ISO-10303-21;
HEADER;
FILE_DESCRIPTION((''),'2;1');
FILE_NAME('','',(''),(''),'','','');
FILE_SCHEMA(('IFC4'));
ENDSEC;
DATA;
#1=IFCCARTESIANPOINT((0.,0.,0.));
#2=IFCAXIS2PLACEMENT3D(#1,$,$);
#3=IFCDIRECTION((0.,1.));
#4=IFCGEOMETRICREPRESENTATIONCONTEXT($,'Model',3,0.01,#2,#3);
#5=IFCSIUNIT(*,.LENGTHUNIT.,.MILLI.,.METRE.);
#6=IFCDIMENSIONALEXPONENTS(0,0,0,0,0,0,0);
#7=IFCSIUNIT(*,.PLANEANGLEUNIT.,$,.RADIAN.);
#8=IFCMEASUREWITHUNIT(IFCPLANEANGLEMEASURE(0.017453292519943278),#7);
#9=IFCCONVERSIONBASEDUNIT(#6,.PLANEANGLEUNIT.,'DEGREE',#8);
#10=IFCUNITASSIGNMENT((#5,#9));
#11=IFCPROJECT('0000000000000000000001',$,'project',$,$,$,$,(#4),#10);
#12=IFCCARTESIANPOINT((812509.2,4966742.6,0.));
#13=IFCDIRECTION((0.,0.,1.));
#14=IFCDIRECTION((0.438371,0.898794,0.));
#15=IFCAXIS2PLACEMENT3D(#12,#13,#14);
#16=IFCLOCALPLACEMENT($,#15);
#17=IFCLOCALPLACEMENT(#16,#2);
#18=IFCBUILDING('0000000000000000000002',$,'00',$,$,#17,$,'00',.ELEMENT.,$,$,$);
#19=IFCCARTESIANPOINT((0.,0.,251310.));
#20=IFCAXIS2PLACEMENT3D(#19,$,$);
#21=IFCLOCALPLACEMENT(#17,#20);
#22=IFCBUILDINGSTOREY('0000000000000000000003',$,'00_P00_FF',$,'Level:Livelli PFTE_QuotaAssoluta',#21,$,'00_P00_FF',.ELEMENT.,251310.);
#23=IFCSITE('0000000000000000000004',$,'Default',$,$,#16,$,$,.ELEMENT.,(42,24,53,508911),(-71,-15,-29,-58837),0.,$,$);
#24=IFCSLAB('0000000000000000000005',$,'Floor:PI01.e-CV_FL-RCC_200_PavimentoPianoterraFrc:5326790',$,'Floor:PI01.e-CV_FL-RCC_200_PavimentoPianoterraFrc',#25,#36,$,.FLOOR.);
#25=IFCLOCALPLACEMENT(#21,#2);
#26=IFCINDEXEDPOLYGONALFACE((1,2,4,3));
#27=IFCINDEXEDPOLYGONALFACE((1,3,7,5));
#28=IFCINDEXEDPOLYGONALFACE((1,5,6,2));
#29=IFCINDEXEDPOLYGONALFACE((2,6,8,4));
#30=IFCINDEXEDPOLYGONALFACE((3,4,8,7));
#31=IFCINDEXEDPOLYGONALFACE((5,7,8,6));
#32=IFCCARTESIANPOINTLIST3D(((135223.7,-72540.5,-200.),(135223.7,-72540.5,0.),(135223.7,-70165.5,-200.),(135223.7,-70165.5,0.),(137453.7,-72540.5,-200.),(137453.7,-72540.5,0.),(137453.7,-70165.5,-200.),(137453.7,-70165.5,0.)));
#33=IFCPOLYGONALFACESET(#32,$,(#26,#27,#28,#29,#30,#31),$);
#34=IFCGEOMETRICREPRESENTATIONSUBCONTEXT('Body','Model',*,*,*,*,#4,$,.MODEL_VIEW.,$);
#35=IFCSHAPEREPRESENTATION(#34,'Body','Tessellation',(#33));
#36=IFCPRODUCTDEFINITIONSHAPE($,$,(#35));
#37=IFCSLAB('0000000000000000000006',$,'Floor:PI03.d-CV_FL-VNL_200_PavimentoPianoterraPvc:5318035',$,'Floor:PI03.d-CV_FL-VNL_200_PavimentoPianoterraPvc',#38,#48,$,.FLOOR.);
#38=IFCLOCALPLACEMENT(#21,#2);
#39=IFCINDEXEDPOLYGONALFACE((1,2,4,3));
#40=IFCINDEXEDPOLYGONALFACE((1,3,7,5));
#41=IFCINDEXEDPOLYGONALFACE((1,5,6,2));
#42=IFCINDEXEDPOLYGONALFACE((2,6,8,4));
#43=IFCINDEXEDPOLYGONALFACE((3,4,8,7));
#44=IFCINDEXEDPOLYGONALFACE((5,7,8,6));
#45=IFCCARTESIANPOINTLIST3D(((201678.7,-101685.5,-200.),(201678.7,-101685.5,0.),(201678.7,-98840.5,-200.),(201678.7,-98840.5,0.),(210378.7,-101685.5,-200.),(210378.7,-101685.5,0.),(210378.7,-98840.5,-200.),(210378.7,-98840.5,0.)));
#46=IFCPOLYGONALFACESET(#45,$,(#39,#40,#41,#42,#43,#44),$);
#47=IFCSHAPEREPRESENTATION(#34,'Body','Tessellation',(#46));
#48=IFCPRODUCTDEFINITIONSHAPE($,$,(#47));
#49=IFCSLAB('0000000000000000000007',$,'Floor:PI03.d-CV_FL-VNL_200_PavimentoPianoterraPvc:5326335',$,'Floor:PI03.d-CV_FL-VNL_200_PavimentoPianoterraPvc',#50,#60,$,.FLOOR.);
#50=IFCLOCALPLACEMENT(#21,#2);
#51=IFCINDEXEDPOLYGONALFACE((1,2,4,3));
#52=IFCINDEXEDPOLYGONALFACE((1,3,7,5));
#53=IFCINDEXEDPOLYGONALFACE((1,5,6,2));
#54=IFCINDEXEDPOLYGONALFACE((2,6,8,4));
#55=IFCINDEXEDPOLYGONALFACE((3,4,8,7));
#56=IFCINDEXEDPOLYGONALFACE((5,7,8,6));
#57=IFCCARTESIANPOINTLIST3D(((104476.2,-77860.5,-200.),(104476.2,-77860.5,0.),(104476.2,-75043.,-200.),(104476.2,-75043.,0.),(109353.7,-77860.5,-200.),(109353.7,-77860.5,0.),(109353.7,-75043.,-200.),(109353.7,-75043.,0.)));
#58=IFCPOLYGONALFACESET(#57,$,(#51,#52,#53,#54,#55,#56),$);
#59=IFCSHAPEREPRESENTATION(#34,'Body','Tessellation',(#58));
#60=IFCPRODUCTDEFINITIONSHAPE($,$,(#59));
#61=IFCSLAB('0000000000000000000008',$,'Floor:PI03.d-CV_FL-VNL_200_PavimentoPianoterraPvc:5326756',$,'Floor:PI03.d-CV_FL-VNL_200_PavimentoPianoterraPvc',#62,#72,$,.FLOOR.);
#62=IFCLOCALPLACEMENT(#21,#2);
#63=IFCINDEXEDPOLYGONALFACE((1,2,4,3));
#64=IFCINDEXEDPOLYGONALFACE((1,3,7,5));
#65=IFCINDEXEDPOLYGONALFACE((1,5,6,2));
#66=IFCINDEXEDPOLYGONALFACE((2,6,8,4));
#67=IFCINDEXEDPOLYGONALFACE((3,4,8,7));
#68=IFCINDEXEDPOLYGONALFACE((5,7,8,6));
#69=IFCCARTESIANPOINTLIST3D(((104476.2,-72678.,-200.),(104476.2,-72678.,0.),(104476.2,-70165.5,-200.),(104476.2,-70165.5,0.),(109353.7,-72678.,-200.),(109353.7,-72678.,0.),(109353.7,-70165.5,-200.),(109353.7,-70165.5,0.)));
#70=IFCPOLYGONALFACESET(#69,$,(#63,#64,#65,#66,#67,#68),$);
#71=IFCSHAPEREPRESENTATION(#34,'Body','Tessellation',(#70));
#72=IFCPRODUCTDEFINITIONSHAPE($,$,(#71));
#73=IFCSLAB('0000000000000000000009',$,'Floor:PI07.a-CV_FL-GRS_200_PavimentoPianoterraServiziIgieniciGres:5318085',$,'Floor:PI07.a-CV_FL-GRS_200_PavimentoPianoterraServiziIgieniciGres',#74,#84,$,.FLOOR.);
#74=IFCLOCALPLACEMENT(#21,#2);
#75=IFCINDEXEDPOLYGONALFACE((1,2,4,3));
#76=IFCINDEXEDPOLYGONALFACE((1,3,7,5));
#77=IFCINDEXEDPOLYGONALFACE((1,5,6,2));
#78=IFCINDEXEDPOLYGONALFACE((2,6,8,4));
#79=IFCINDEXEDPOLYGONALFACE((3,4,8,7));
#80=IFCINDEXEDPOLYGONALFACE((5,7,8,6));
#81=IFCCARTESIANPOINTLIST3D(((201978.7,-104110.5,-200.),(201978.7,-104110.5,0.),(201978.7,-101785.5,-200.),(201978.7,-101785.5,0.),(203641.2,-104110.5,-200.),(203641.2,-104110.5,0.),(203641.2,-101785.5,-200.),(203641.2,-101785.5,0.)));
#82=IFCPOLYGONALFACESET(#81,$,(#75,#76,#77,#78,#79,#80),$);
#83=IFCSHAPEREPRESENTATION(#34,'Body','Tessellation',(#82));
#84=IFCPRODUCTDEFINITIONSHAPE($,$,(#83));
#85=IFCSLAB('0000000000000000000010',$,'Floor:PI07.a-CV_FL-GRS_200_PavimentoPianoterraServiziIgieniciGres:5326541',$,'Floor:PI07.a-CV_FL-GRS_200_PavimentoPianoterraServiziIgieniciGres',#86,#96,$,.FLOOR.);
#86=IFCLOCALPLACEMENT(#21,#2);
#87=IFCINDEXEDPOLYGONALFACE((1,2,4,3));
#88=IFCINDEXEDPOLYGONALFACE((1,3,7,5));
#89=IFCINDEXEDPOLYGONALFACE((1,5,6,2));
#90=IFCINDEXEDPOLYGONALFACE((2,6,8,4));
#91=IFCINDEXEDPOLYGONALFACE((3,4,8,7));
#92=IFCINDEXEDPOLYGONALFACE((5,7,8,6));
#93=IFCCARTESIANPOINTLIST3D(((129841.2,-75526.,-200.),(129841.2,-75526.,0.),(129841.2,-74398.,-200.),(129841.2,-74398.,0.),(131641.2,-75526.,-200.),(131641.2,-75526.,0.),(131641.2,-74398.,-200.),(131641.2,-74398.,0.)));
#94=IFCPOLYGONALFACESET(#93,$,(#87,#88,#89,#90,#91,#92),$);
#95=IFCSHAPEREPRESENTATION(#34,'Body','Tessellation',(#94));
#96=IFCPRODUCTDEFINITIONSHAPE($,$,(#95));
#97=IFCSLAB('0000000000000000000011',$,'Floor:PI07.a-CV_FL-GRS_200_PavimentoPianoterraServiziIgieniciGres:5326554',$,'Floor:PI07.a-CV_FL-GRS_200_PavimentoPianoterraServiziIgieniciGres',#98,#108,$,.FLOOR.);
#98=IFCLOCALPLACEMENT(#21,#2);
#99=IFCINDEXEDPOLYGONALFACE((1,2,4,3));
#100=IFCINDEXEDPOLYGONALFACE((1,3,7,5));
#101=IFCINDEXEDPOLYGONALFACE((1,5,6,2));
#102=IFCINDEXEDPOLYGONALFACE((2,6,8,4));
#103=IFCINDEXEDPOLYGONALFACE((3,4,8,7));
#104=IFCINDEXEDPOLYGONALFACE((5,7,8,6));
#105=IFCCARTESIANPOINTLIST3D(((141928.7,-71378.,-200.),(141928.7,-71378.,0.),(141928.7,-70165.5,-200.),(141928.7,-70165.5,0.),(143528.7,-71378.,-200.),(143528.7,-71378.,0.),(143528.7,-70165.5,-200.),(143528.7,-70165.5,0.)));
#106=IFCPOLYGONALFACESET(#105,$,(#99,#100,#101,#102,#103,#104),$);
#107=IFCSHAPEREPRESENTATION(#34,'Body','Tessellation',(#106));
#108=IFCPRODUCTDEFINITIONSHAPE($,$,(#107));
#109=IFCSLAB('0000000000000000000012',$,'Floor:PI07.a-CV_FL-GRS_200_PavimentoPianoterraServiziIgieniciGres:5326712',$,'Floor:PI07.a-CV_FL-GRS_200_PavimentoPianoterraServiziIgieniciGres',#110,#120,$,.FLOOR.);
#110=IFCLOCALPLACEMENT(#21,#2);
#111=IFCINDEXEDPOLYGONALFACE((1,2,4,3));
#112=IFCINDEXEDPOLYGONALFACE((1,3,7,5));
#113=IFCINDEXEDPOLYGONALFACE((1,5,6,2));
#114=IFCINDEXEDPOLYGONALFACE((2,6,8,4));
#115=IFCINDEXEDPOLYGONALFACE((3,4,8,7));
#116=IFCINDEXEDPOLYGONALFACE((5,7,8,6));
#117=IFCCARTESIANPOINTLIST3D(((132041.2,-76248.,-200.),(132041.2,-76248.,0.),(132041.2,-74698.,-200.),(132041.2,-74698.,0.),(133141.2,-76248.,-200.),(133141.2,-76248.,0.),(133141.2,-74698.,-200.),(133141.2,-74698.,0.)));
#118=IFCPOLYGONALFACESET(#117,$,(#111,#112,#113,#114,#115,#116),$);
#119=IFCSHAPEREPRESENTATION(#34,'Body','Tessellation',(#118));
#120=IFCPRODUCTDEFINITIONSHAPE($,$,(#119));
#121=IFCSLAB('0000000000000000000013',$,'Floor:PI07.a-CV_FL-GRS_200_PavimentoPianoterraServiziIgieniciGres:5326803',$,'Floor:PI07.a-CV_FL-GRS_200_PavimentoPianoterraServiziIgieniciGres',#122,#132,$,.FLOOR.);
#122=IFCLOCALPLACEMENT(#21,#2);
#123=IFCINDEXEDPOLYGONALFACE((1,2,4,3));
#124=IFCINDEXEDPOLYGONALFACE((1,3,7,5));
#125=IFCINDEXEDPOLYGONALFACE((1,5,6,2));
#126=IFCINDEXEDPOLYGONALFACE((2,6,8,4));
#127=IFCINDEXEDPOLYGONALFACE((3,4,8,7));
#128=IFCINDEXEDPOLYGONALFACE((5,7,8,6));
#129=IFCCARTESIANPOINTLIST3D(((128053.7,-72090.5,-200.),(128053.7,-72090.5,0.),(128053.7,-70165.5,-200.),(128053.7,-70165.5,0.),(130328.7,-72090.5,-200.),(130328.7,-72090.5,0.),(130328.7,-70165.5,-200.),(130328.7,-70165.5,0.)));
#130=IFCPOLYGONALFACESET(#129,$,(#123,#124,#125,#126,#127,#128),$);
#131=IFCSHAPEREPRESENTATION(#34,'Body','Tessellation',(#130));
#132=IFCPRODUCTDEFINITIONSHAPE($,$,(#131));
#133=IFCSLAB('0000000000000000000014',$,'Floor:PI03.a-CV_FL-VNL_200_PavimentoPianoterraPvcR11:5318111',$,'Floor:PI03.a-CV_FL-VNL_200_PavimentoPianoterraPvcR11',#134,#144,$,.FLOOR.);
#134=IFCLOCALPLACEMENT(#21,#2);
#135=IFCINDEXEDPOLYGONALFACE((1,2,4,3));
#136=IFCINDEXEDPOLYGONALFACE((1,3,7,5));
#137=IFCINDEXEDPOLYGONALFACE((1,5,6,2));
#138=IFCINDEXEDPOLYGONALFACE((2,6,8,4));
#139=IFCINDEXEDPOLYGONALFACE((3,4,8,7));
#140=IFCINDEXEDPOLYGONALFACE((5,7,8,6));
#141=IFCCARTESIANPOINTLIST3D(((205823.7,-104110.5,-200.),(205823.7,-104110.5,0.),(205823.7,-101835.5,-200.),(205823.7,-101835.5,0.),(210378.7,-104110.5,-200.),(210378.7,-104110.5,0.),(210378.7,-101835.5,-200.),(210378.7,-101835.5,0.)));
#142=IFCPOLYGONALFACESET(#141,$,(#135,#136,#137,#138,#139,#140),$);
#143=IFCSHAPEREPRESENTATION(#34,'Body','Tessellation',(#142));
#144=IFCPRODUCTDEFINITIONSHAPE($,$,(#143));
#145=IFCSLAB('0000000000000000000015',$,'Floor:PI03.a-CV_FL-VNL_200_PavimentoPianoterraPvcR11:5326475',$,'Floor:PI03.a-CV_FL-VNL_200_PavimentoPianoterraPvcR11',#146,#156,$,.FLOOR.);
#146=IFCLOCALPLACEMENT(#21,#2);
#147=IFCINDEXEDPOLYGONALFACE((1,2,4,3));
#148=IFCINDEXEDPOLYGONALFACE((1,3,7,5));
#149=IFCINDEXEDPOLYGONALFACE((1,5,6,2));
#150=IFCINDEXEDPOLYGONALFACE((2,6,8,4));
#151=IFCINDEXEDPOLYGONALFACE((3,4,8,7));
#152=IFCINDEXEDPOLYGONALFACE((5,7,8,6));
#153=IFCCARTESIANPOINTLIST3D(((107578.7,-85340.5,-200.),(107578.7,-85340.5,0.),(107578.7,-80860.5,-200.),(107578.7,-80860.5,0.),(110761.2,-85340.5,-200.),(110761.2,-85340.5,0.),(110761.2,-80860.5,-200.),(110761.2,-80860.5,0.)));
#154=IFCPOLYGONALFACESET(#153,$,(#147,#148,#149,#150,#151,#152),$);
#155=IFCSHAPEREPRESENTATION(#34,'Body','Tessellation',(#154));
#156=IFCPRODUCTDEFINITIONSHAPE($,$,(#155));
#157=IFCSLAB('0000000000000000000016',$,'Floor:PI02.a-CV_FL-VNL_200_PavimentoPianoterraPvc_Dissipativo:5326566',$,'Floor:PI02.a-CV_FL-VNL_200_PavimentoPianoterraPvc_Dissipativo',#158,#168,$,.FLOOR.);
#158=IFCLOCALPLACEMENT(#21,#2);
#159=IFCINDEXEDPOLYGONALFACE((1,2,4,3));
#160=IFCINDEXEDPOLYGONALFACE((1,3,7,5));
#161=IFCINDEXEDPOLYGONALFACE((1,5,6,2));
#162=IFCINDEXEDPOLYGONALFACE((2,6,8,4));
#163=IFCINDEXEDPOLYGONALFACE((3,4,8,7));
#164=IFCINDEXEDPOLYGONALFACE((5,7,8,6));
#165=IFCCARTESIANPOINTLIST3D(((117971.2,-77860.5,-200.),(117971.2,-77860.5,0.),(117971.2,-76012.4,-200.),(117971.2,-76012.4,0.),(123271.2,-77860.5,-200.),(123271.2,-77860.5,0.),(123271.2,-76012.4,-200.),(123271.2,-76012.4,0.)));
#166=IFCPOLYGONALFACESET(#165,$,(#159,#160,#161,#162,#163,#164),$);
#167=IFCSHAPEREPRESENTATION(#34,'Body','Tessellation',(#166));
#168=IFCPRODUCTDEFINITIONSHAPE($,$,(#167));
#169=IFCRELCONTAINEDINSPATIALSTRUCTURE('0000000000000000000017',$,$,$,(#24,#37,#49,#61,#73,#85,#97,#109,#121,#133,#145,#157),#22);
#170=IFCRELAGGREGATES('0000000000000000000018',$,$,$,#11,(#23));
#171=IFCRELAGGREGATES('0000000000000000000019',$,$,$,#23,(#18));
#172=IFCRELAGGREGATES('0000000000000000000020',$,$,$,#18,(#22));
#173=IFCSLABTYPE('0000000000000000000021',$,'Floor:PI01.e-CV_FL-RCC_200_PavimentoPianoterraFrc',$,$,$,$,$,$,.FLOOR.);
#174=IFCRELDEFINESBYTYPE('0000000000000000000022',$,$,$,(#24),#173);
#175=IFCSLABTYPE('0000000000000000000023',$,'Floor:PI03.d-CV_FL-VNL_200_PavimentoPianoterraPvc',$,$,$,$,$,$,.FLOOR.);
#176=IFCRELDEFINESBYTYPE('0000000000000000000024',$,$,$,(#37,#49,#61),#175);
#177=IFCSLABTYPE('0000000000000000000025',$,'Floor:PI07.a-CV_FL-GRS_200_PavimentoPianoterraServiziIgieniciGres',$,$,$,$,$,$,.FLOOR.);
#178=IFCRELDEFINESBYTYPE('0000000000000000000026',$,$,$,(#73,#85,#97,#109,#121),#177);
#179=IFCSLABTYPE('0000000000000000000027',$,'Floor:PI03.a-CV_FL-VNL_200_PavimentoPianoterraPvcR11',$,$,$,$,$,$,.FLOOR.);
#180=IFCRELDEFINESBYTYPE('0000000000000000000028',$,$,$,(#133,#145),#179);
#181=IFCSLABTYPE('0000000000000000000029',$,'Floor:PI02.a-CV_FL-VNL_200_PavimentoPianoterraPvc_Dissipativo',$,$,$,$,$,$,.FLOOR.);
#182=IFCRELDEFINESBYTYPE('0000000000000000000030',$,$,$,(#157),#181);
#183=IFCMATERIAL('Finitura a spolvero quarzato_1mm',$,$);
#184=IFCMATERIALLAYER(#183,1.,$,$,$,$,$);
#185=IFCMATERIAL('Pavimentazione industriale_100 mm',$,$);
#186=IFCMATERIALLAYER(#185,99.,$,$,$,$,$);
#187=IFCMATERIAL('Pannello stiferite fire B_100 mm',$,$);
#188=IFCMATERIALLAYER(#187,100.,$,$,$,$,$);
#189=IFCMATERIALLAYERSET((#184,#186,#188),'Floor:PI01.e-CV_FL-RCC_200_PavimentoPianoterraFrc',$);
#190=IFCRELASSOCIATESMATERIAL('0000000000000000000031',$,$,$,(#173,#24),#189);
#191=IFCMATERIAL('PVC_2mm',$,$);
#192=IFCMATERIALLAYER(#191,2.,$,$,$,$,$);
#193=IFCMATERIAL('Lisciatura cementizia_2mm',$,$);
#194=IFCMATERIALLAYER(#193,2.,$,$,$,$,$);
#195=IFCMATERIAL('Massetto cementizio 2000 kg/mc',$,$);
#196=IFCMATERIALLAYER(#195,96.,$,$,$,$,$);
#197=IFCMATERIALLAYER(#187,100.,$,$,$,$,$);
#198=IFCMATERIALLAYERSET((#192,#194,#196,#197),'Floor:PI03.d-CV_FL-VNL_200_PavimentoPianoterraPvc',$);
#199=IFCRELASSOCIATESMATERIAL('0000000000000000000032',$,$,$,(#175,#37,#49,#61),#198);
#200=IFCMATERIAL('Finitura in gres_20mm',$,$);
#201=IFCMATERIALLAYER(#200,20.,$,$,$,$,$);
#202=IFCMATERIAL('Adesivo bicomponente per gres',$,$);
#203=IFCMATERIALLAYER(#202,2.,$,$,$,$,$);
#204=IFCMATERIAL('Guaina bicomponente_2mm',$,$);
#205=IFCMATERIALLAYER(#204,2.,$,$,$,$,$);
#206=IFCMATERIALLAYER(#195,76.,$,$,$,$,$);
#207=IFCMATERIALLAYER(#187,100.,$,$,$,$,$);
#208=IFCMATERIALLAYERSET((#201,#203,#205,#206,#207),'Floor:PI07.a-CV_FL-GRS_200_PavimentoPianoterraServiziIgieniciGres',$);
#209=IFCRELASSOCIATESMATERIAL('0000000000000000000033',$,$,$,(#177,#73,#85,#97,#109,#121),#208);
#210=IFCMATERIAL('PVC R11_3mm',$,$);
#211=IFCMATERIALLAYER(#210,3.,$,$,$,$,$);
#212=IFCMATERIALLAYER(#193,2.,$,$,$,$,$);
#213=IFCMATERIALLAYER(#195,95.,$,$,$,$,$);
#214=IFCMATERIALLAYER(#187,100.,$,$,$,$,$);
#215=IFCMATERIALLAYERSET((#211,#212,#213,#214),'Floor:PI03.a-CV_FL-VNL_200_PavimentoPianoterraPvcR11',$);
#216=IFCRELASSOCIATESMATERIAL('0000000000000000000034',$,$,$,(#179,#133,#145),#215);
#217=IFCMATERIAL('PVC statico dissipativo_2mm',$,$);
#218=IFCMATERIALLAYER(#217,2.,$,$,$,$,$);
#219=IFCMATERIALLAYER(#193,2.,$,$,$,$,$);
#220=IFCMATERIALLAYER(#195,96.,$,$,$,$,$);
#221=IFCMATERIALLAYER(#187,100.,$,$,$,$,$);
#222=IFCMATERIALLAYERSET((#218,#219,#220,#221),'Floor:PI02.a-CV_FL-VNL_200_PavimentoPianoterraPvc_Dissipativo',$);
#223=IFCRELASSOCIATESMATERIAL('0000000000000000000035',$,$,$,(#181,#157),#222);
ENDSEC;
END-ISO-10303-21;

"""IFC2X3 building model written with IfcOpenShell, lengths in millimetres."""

from ifc_helpers import new_model, entity, si_unit, converted_unit, direction, frame, frame_2d, origin, origin_2d_with_axis, place, context, subcontext, project, spatial, rectangle, extrude, material, layer, layer_set, layer_usage, type_object, element, save


model = new_model("IFC2X3")

# Units and contexts
model_context = context("Model", 3, precision=0.01, world=origin(), true_north=direction((0.0, 1.0)))
body_context = subcontext(model_context, "Body", "Model", "MODEL_VIEW")
ifc_project = project(units=[si_unit("LENGTHUNIT", "METRE", prefix="MILLI"), converted_unit("PLANEANGLEUNIT", "DEGREE", entity("IfcPlaneAngleMeasure", 0.017453292519943278), si_unit("PLANEANGLEUNIT", "RADIAN"), dimensions=[0, 0, 0, 0, 0, 0, 0])], contexts=[model_context])

# Site, building, storey
site_placement = place(None, frame((812509.2, 4966742.6, 0.0), z_axis=(0.0, 0.0, 1.0), x_axis=(0.438371, 0.898794, 0.0)))
site = spatial("IfcSite", under=ifc_project, at=site_placement, Name="Default", CompositionType="ELEMENT", RefLatitude=(42, 24, 53, 508911), RefLongitude=(-71, -15, -29, -58837), RefElevation=0.0)
building_placement = place(site_placement, origin())
building = spatial("IfcBuilding", under=site, at=building_placement, Name="00", LongName="00", CompositionType="ELEMENT")
storey_placement = place(building_placement, frame((0.0, 0.0, 251310.0)))
storey = spatial("IfcBuildingStorey", under=building, at=storey_placement, Name="00_P00_FF", ObjectType="Level:Livelli PFTE_QuotaAssoluta", LongName="00_P00_FF", CompositionType="ELEMENT", Elevation=251310.0)

# Slabs
ifc_material_1 = material(Name="Finitura a spolvero quarzato_1mm")
ifc_layer_1 = layer(ifc_material_1, 1.0)
ifc_material_2 = material(Name="Pavimentazione industriale_100 mm")
ifc_layer_2 = layer(ifc_material_2, 99.0)
ifc_material_3 = material(Name="Pannello stiferite fire B_100 mm")
ifc_layer_3 = layer(ifc_material_3, 100.0)
ifc_layer_set_1 = layer_set([ifc_layer_1, ifc_layer_2, ifc_layer_3], Name="Floor:PI01.e-CV_FL-RCC_200_PavimentoPianoterraFrc")
slab_type_1 = type_object("IfcSlabType", Name="Floor:PI01.e-CV_FL-RCC_200_PavimentoPianoterraFrc", PredefinedType="FLOOR", material=ifc_layer_set_1)
ifc_layer_usage_1 = layer_usage(ifc_layer_set_1, "AXIS3", "POSITIVE", 0.0)
slab_1_placement = place(storey_placement, origin())
element("IfcSlab", 1, at=slab_1_placement, inside=storey, type_object=slab_type_1, material=ifc_layer_usage_1, Name="Floor:PI01.e-CV_FL-RCC_200_PavimentoPianoterraFrc:5326790", ObjectType="Floor:PI01.e-CV_FL-RCC_200_PavimentoPianoterraFrc", PredefinedType="FLOOR", context=body_context, shape_type="SweptSolid", body=[
    extrude(rectangle(XDim=2375.0, YDim=2230.0, at=frame_2d((0.0, 0.0), x_axis=(1.0, 0.0))), frame((136338.7, -71353.0, 0.0), z_axis=(0.0, 0.0, -1.0), x_axis=(0.0, 1.0, 0.0)), (0.0, 0.0, 1.0), 200.0),
])
ifc_material_4 = material(Name="PVC_2mm")
ifc_layer_4 = layer(ifc_material_4, 2.0)
ifc_material_5 = material(Name="Lisciatura cementizia_2mm")
ifc_layer_5 = layer(ifc_material_5, 2.0)
ifc_material_6 = material(Name="Massetto cementizio 2000 kg/mc")
ifc_layer_6 = layer(ifc_material_6, 96.0)
ifc_layer_7 = layer(ifc_material_3, 100.0)
ifc_layer_set_2 = layer_set([ifc_layer_4, ifc_layer_5, ifc_layer_6, ifc_layer_7], Name="Floor:PI03.d-CV_FL-VNL_200_PavimentoPianoterraPvc")
ifc_layer_usage_2 = layer_usage(ifc_layer_set_2, "AXIS3", "POSITIVE", 0.0)
slab_type_2 = type_object("IfcSlabType", Name="Floor:PI03.d-CV_FL-VNL_200_PavimentoPianoterraPvc", PredefinedType="FLOOR", material=ifc_layer_set_2)
slab_2_placement = place(storey_placement, origin())
element("IfcSlab", 2, at=slab_2_placement, inside=storey, type_object=slab_type_2, material=ifc_layer_usage_2, Name="Floor:PI03.d-CV_FL-VNL_200_PavimentoPianoterraPvc:5318035", ObjectType="Floor:PI03.d-CV_FL-VNL_200_PavimentoPianoterraPvc", PredefinedType="FLOOR", context=body_context, shape_type="SweptSolid", body=[
    extrude(rectangle(XDim=2845.0, YDim=8700.0, at=frame_2d((0.0, 0.0), x_axis=(1.0, 0.0))), frame((206028.7, -100263.0, 0.0), z_axis=(0.0, 0.0, -1.0), x_axis=(0.0, 1.0, 0.0)), (0.0, 0.0, 1.0), 200.0),
])
ifc_layer_usage_3 = layer_usage(ifc_layer_set_2, "AXIS3", "POSITIVE", 0.0)
slab_3_placement = place(storey_placement, origin())
element("IfcSlab", 3, at=slab_3_placement, inside=storey, type_object=slab_type_2, material=ifc_layer_usage_3, Name="Floor:PI03.d-CV_FL-VNL_200_PavimentoPianoterraPvc:5326335", ObjectType="Floor:PI03.d-CV_FL-VNL_200_PavimentoPianoterraPvc", PredefinedType="FLOOR", context=body_context, shape_type="SweptSolid", body=[
    extrude(rectangle(XDim=4877.5, YDim=2817.5, at=frame_2d((0.0, 0.0), x_axis=(1.0, 0.0))), frame((106914.9, -76451.7, 0.0), z_axis=(0.0, 0.0, -1.0), x_axis=(1.0, 0.0, 0.0)), (0.0, 0.0, 1.0), 200.0),
])
ifc_layer_usage_4 = layer_usage(ifc_layer_set_2, "AXIS3", "POSITIVE", 0.0)
slab_4_placement = place(storey_placement, origin())
element("IfcSlab", 4, at=slab_4_placement, inside=storey, type_object=slab_type_2, material=ifc_layer_usage_4, Name="Floor:PI03.d-CV_FL-VNL_200_PavimentoPianoterraPvc:5326756", ObjectType="Floor:PI03.d-CV_FL-VNL_200_PavimentoPianoterraPvc", PredefinedType="FLOOR", context=body_context, shape_type="SweptSolid", body=[
    extrude(rectangle(XDim=2512.5, YDim=4877.5, at=frame_2d((0.0, 0.0), x_axis=(1.0, 0.0))), frame((106914.9, -71421.7, 0.0), z_axis=(0.0, 0.0, -1.0), x_axis=(0.0, -1.0, 0.0)), (0.0, 0.0, 1.0), 200.0),
])
ifc_material_7 = material(Name="Finitura in gres_20mm")
ifc_layer_8 = layer(ifc_material_7, 20.0)
ifc_material_8 = material(Name="Adesivo bicomponente per gres")
ifc_layer_9 = layer(ifc_material_8, 2.0)
ifc_material_9 = material(Name="Guaina bicomponente_2mm")
ifc_layer_10 = layer(ifc_material_9, 2.0)
ifc_layer_11 = layer(ifc_material_6, 76.0)
ifc_layer_12 = layer(ifc_material_3, 100.0)
ifc_layer_set_3 = layer_set([ifc_layer_8, ifc_layer_9, ifc_layer_10, ifc_layer_11, ifc_layer_12], Name="Floor:PI07.a-CV_FL-GRS_200_PavimentoPianoterraServiziIgieniciGres")
ifc_layer_usage_5 = layer_usage(ifc_layer_set_3, "AXIS3", "POSITIVE", 0.0)
slab_type_3 = type_object("IfcSlabType", Name="Floor:PI07.a-CV_FL-GRS_200_PavimentoPianoterraServiziIgieniciGres", PredefinedType="FLOOR", material=ifc_layer_set_3)
slab_5_placement = place(storey_placement, origin())
element("IfcSlab", 5, at=slab_5_placement, inside=storey, type_object=slab_type_3, material=ifc_layer_usage_5, Name="Floor:PI07.a-CV_FL-GRS_200_PavimentoPianoterraServiziIgieniciGres:5318085", ObjectType="Floor:PI07.a-CV_FL-GRS_200_PavimentoPianoterraServiziIgieniciGres", PredefinedType="FLOOR", context=body_context, shape_type="SweptSolid", body=[
    extrude(rectangle(XDim=2325.0, YDim=1662.5, at=frame_2d((0.0, 0.0), x_axis=(1.0, 0.0))), frame((202809.9, -102948.0, 0.0), z_axis=(0.0, 0.0, -1.0), x_axis=(0.0, 1.0, 0.0)), (0.0, 0.0, 1.0), 200.0),
])
ifc_layer_usage_6 = layer_usage(ifc_layer_set_3, "AXIS3", "POSITIVE", 0.0)
slab_6_placement = place(storey_placement, origin())
element("IfcSlab", 6, at=slab_6_placement, inside=storey, type_object=slab_type_3, material=ifc_layer_usage_6, Name="Floor:PI07.a-CV_FL-GRS_200_PavimentoPianoterraServiziIgieniciGres:5326541", ObjectType="Floor:PI07.a-CV_FL-GRS_200_PavimentoPianoterraServiziIgieniciGres", PredefinedType="FLOOR", context=body_context, shape_type="SweptSolid", body=[
    extrude(rectangle(XDim=1128.0, YDim=1800.0, at=frame_2d((0.0, 0.0), x_axis=(1.0, 0.0))), frame((130741.2, -74962.0, 0.0), z_axis=(0.0, 0.0, -1.0), x_axis=(0.0, 1.0, 0.0)), (0.0, 0.0, 1.0), 200.0),
])
ifc_layer_usage_7 = layer_usage(ifc_layer_set_3, "AXIS3", "POSITIVE", 0.0)
slab_7_placement = place(storey_placement, origin())
element("IfcSlab", 7, at=slab_7_placement, inside=storey, type_object=slab_type_3, material=ifc_layer_usage_7, Name="Floor:PI07.a-CV_FL-GRS_200_PavimentoPianoterraServiziIgieniciGres:5326554", ObjectType="Floor:PI07.a-CV_FL-GRS_200_PavimentoPianoterraServiziIgieniciGres", PredefinedType="FLOOR", context=body_context, shape_type="SweptSolid", body=[
    extrude(rectangle(XDim=1212.5, YDim=1600.0, at=frame_2d((0.0, 0.0), x_axis=(1.0, 0.0))), frame((142728.7, -70771.7, 0.0), z_axis=(0.0, 0.0, -1.0), x_axis=(0.0, 1.0, 0.0)), (0.0, 0.0, 1.0), 200.0),
])
ifc_layer_usage_8 = layer_usage(ifc_layer_set_3, "AXIS3", "POSITIVE", 0.0)
slab_8_placement = place(storey_placement, origin())
element("IfcSlab", 8, at=slab_8_placement, inside=storey, type_object=slab_type_3, material=ifc_layer_usage_8, Name="Floor:PI07.a-CV_FL-GRS_200_PavimentoPianoterraServiziIgieniciGres:5326712", ObjectType="Floor:PI07.a-CV_FL-GRS_200_PavimentoPianoterraServiziIgieniciGres", PredefinedType="FLOOR", context=body_context, shape_type="SweptSolid", body=[
    extrude(rectangle(XDim=1550.0, YDim=1100.0, at=frame_2d((0.0, 0.0), x_axis=(1.0, 0.0))), frame((132591.2, -75473.0, 0.0), z_axis=(0.0, 0.0, -1.0), x_axis=(0.0, 1.0, 0.0)), (0.0, 0.0, 1.0), 200.0),
])
ifc_layer_usage_9 = layer_usage(ifc_layer_set_3, "AXIS3", "POSITIVE", 0.0)
slab_9_placement = place(storey_placement, origin())
element("IfcSlab", 9, at=slab_9_placement, inside=storey, type_object=slab_type_3, material=ifc_layer_usage_9, Name="Floor:PI07.a-CV_FL-GRS_200_PavimentoPianoterraServiziIgieniciGres:5326803", ObjectType="Floor:PI07.a-CV_FL-GRS_200_PavimentoPianoterraServiziIgieniciGres", PredefinedType="FLOOR", context=body_context, shape_type="SweptSolid", body=[
    extrude(rectangle(XDim=1925.0, YDim=2275.0, at=frame_2d((0.0, 0.0), x_axis=(1.0, 0.0))), frame((129191.2, -71128.0, 0.0), z_axis=(0.0, 0.0, -1.0), x_axis=(0.0, 1.0, 0.0)), (0.0, 0.0, 1.0), 200.0),
])
ifc_material_10 = material(Name="PVC R11_3mm")
ifc_layer_13 = layer(ifc_material_10, 3.0)
ifc_layer_14 = layer(ifc_material_5, 2.0)
ifc_layer_15 = layer(ifc_material_6, 95.0)
ifc_layer_16 = layer(ifc_material_3, 100.0)
ifc_layer_set_4 = layer_set([ifc_layer_13, ifc_layer_14, ifc_layer_15, ifc_layer_16], Name="Floor:PI03.a-CV_FL-VNL_200_PavimentoPianoterraPvcR11")
ifc_layer_usage_10 = layer_usage(ifc_layer_set_4, "AXIS3", "POSITIVE", 0.0)
slab_type_4 = type_object("IfcSlabType", Name="Floor:PI03.a-CV_FL-VNL_200_PavimentoPianoterraPvcR11", PredefinedType="FLOOR", material=ifc_layer_set_4)
slab_10_placement = place(storey_placement, origin())
element("IfcSlab", 10, at=slab_10_placement, inside=storey, type_object=slab_type_4, material=ifc_layer_usage_10, Name="Floor:PI03.a-CV_FL-VNL_200_PavimentoPianoterraPvcR11:5318111", ObjectType="Floor:PI03.a-CV_FL-VNL_200_PavimentoPianoterraPvcR11", PredefinedType="FLOOR", context=body_context, shape_type="SweptSolid", body=[
    extrude(rectangle(XDim=2275.0, YDim=4555.0, at=origin_2d_with_axis()), frame((208101.2, -102973.0, 0.0), z_axis=(0.0, 0.0, -1.0), x_axis=(0.0, 1.0, 0.0)), (0.0, 0.0, 1.0), 200.0),
])
ifc_layer_usage_11 = layer_usage(ifc_layer_set_4, "AXIS3", "POSITIVE", 0.0)
slab_11_placement = place(storey_placement, origin())
element("IfcSlab", 11, at=slab_11_placement, inside=storey, type_object=slab_type_4, material=ifc_layer_usage_11, Name="Floor:PI03.a-CV_FL-VNL_200_PavimentoPianoterraPvcR11:5326475", ObjectType="Floor:PI03.a-CV_FL-VNL_200_PavimentoPianoterraPvcR11", PredefinedType="FLOOR", context=body_context, shape_type="SweptSolid", body=[
    extrude(rectangle(XDim=4480.0, YDim=3182.5, at=frame_2d((0.0, 0.0), x_axis=(1.0, 0.0))), frame((109169.9, -83100.5, 0.0), z_axis=(0.0, 0.0, -1.0), x_axis=(0.0, 1.0, 0.0)), (0.0, 0.0, 1.0), 200.0),
])

# Shared definitions
ifc_material_11 = material(Name="PVC statico dissipativo_2mm")
ifc_layer_17 = layer(ifc_material_11, 2.0)
ifc_layer_18 = layer(ifc_material_5, 2.0)
ifc_layer_19 = layer(ifc_material_6, 96.0)
ifc_layer_20 = layer(ifc_material_3, 100.0)
ifc_layer_set_5 = layer_set([ifc_layer_17, ifc_layer_18, ifc_layer_19, ifc_layer_20], Name="Floor:PI02.a-CV_FL-VNL_200_PavimentoPianoterraPvc_Dissipativo")
slab_type_5 = type_object("IfcSlabType", Name="Floor:PI02.a-CV_FL-VNL_200_PavimentoPianoterraPvc_Dissipativo", PredefinedType="FLOOR", material=ifc_layer_set_5)

# Slab
ifc_layer_usage_12 = layer_usage(ifc_layer_set_5, "AXIS3", "POSITIVE", 0.0)
slab_12_placement = place(storey_placement, origin())
element("IfcSlab", 12, at=slab_12_placement, inside=storey, type_object=slab_type_5, material=ifc_layer_usage_12, Name="Floor:PI02.a-CV_FL-VNL_200_PavimentoPianoterraPvc_Dissipativo:5326566", ObjectType="Floor:PI02.a-CV_FL-VNL_200_PavimentoPianoterraPvc_Dissipativo", PredefinedType="FLOOR", context=body_context, shape_type="SweptSolid", body=[
    extrude(rectangle(XDim=1848.1, YDim=5300.0, at=frame_2d((0.0, 0.0), x_axis=(1.0, 0.0))), frame((120621.2, -76936.4, 0.0), z_axis=(0.0, 0.0, -1.0), x_axis=(0.0, 1.0, 0.0)), (0.0, 0.0, 1.0), 200.0),
])

save(model, "model.ifc")
